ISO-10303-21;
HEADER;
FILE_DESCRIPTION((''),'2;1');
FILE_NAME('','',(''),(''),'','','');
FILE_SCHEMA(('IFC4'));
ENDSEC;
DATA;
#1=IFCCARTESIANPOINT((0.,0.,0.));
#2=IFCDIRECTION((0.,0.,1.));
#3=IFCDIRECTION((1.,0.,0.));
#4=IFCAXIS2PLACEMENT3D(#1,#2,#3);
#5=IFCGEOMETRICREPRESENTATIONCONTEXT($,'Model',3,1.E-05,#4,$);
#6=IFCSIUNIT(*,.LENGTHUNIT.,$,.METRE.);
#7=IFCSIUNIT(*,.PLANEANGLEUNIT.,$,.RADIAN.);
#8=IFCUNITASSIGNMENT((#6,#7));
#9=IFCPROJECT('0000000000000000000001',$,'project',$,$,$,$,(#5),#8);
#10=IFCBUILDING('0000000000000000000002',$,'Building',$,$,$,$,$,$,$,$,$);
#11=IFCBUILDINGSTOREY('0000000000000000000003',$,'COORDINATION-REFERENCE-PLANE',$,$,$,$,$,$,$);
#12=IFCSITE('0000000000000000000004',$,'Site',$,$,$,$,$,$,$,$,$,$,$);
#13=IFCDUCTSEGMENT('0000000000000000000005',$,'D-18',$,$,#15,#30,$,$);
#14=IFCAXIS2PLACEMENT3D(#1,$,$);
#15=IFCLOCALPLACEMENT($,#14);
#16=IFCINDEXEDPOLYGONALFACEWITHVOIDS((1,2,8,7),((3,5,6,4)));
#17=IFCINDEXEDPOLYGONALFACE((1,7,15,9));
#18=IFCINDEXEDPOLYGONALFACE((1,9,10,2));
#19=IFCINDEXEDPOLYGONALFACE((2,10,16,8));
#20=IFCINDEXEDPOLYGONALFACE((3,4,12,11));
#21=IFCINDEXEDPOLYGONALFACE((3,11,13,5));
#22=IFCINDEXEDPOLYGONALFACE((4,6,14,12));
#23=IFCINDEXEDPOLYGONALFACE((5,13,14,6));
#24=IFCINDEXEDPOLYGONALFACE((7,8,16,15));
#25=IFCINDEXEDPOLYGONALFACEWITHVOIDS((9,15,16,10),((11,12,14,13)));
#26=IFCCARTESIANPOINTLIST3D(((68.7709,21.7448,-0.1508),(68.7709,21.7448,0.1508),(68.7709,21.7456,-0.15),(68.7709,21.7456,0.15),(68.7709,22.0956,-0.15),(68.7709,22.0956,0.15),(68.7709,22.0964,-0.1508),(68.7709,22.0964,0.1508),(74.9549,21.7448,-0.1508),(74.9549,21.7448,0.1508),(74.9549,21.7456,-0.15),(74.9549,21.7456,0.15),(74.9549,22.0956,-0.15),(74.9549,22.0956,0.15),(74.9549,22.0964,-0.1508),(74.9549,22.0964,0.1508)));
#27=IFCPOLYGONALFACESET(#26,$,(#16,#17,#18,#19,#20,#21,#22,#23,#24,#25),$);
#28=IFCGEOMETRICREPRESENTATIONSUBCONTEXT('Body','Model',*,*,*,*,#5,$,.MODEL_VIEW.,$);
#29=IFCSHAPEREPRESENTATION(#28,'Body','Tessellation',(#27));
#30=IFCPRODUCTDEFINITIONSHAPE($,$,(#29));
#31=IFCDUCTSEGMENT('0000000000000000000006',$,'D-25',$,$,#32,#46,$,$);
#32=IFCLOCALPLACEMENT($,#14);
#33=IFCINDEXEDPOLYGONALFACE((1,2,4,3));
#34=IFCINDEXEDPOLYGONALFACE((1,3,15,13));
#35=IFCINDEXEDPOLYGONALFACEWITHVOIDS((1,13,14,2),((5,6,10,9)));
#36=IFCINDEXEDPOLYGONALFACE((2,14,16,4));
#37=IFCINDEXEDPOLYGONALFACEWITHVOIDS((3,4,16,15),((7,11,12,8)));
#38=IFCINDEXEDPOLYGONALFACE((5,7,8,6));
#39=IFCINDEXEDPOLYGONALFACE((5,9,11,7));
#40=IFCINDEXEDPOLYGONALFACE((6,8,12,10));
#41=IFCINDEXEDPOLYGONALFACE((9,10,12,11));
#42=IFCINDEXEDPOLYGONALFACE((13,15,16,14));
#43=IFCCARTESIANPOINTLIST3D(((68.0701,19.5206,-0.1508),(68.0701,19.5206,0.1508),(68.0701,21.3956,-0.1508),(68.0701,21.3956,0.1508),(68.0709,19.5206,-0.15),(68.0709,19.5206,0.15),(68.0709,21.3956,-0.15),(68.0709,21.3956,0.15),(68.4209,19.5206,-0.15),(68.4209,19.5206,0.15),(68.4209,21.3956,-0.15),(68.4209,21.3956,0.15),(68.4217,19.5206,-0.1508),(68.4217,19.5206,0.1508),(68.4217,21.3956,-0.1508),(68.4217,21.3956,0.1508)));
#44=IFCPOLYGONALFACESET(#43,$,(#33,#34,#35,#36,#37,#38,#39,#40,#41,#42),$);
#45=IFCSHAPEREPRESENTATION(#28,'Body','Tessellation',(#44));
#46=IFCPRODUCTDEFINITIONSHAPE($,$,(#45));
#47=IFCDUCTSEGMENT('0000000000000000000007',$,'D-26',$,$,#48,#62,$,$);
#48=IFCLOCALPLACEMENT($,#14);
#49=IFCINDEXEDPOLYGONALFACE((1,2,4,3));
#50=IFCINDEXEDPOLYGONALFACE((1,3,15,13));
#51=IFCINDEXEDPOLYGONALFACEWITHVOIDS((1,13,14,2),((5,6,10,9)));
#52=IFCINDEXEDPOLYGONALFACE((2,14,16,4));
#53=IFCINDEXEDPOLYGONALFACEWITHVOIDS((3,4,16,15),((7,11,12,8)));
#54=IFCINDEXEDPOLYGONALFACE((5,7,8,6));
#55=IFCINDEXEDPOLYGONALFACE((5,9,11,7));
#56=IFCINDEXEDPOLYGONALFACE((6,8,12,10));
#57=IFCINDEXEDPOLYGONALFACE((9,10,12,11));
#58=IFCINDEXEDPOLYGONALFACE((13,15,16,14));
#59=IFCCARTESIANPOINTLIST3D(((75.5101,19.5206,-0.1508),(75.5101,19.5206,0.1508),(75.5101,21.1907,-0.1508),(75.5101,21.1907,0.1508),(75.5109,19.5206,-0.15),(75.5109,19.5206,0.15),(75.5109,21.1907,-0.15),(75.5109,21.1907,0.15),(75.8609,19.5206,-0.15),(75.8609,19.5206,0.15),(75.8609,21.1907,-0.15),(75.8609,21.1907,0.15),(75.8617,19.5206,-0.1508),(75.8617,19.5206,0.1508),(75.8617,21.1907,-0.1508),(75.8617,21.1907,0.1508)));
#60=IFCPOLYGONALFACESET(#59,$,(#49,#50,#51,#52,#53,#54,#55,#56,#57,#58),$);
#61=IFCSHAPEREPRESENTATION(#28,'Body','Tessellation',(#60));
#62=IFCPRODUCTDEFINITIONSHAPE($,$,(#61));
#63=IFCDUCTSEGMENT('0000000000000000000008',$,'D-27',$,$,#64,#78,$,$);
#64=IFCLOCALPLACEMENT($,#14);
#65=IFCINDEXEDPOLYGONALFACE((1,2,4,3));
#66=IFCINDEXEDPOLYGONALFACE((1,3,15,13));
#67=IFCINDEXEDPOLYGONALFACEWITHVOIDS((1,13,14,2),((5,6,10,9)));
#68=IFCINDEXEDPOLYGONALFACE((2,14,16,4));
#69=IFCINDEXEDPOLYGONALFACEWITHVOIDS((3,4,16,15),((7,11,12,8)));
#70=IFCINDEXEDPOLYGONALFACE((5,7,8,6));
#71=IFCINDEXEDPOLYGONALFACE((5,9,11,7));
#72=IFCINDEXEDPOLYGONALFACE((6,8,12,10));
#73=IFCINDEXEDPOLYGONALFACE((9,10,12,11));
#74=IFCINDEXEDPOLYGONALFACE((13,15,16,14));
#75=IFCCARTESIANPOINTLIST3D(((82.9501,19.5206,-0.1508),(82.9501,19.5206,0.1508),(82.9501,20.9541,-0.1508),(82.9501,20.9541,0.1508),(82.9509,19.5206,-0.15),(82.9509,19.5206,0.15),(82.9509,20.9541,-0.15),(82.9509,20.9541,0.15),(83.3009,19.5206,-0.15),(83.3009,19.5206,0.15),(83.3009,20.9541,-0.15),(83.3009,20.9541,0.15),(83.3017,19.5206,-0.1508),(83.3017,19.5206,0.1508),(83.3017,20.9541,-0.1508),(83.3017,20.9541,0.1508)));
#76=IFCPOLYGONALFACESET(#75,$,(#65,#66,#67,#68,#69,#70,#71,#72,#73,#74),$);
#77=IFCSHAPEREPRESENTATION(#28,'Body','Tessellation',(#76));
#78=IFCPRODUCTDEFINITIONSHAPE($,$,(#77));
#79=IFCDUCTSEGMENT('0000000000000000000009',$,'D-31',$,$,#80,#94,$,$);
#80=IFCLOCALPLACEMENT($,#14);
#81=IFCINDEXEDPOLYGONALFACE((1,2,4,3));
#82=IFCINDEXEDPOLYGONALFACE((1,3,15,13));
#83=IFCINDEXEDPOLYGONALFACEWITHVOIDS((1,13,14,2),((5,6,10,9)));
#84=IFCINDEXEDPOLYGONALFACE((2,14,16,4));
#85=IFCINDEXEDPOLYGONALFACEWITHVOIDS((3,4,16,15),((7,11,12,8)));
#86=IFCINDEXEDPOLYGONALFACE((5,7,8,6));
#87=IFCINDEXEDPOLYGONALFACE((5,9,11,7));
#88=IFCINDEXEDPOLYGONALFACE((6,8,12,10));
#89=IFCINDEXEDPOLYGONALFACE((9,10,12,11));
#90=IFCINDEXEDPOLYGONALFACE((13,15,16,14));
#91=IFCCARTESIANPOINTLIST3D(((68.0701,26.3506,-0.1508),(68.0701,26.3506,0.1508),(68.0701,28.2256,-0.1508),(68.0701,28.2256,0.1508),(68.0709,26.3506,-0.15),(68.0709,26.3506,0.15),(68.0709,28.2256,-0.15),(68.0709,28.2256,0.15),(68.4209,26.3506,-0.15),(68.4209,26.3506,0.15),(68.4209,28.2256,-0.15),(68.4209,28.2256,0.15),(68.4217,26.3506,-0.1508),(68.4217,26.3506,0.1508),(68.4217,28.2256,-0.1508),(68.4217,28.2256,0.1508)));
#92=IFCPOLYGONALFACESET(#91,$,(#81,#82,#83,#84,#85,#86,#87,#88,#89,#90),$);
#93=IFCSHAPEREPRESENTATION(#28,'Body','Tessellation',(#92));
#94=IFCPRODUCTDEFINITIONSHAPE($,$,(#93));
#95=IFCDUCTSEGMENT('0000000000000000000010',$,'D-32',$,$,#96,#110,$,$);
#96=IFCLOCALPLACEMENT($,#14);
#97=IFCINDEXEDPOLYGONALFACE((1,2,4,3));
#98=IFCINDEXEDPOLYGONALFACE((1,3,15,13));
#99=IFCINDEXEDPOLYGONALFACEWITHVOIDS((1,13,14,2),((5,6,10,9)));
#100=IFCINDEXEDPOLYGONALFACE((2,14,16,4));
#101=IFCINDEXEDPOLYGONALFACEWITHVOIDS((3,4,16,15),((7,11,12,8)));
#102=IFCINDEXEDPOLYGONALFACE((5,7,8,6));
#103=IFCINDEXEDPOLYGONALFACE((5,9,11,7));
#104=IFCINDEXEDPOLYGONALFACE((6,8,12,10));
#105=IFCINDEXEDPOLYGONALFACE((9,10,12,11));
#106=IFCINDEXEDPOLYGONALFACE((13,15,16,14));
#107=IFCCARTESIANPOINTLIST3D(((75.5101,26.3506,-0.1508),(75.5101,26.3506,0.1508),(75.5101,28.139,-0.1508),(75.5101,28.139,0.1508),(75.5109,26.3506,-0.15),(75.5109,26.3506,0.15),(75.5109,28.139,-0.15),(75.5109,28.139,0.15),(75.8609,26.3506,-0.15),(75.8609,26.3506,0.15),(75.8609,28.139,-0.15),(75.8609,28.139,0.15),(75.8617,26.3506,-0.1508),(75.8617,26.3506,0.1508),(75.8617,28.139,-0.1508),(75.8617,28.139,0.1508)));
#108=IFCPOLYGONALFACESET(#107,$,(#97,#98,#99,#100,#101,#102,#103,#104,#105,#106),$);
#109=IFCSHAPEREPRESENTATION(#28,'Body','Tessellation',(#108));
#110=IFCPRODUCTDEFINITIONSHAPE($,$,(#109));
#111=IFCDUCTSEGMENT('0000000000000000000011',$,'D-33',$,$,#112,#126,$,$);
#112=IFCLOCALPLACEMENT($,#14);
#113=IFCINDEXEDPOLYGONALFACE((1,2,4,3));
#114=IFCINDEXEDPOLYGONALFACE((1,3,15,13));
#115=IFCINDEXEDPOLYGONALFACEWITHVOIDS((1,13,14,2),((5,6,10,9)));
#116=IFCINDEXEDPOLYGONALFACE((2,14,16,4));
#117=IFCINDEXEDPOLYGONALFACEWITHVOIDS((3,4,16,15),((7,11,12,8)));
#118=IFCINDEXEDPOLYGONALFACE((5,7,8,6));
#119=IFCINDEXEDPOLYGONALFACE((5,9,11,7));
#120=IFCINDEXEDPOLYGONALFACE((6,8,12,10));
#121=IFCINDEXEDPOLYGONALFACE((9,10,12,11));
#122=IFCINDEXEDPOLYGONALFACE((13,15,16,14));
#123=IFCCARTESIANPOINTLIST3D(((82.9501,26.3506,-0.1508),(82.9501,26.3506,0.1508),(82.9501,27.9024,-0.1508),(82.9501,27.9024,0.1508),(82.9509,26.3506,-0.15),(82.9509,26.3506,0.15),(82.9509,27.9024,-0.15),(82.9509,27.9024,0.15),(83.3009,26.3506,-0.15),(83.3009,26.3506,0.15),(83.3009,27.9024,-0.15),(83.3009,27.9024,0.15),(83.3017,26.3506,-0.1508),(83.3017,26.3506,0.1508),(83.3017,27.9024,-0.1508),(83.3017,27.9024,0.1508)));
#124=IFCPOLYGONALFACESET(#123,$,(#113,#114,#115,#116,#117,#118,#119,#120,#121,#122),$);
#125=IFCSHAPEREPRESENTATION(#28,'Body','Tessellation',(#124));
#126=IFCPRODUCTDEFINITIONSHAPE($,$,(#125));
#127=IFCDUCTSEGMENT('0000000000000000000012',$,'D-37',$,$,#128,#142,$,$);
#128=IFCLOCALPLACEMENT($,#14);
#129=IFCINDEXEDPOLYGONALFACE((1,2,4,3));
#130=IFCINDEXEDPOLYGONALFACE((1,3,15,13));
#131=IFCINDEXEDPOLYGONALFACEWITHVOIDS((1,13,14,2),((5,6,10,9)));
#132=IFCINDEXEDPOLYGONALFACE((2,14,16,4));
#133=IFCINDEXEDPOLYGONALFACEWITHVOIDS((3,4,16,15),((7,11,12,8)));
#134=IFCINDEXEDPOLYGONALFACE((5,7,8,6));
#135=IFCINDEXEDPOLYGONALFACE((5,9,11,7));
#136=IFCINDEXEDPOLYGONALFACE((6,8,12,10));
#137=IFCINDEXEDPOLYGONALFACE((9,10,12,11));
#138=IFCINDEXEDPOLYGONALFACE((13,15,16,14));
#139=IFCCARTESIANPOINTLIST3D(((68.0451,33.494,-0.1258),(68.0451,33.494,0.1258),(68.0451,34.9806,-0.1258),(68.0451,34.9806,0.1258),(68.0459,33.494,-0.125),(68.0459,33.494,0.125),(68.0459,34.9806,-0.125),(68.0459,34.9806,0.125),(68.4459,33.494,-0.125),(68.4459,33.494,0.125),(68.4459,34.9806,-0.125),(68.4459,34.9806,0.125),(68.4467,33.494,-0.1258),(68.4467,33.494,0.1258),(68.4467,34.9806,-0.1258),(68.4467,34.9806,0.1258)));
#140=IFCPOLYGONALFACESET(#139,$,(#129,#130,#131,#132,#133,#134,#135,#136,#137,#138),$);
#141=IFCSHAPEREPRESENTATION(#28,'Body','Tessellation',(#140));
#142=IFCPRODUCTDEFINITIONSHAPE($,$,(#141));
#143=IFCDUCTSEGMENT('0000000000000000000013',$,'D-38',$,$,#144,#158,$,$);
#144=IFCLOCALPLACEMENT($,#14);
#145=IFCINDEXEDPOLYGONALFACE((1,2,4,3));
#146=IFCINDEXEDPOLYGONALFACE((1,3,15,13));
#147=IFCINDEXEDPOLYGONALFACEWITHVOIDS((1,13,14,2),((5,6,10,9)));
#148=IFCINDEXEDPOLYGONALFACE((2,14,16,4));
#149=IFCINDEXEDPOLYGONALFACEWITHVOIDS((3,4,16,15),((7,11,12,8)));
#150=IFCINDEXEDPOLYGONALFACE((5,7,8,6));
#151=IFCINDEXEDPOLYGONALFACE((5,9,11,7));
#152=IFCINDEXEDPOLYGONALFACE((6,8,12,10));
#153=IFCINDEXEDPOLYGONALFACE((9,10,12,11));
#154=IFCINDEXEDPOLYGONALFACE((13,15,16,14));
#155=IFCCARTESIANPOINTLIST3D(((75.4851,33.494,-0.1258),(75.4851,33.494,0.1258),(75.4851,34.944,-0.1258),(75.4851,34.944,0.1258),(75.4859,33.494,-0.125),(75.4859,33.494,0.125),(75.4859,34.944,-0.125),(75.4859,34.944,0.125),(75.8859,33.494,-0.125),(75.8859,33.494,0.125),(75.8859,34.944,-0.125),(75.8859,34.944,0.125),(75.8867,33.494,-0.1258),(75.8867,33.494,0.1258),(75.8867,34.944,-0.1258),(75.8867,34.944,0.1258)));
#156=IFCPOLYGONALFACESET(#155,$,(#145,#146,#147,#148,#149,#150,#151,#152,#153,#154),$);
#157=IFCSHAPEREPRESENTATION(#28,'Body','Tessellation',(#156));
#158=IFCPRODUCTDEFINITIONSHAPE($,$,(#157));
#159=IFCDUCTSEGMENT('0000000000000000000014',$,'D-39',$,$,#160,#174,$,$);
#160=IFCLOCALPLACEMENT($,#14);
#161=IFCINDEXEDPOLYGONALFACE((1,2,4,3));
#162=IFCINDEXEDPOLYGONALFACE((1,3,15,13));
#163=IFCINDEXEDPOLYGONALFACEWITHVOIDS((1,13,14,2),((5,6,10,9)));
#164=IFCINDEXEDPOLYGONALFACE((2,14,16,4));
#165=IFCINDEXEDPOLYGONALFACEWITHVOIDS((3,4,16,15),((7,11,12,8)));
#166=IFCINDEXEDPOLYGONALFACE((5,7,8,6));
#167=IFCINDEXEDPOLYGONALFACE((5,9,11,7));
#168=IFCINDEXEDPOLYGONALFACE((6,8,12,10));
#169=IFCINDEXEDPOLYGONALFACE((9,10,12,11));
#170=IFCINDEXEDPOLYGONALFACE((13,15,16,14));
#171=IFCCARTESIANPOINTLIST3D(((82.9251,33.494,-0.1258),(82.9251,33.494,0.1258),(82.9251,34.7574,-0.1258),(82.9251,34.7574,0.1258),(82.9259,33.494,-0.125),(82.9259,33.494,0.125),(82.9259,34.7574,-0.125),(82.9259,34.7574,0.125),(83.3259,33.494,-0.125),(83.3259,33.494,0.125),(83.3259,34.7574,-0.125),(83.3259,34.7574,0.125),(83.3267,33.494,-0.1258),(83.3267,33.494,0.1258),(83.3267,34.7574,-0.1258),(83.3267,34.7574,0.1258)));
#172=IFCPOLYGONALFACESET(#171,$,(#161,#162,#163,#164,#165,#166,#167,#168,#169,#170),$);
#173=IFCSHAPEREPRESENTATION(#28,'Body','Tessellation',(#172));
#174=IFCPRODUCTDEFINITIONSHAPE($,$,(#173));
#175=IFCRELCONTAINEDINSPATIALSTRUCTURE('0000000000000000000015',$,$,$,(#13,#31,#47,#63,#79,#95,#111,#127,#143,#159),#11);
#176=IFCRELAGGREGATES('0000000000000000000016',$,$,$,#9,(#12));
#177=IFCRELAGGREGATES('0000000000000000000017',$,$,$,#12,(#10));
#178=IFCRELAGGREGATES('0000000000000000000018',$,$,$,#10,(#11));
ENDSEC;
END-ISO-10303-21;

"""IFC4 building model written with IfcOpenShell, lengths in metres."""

from ifc_helpers import new_model, si_unit, frame, origin, origin_with_axes, place, context, subcontext, project, spatial, hollow_rectangle, extrude, element, save


model = new_model("IFC4")

# Units and contexts
model_context = context("Model", 3, precision=1e-05, world=origin_with_axes())
body_context = subcontext(model_context, "Body", "Model", "MODEL_VIEW")
ifc_project = project(units=[si_unit("LENGTHUNIT", "METRE"), si_unit("PLANEANGLEUNIT", "RADIAN")], contexts=[model_context])

# Site, building, storey
site = spatial("IfcSite", under=ifc_project, Name="Site")
building = spatial("IfcBuilding", under=site, Name="Building")
storey = spatial("IfcBuildingStorey", under=building, Name="COORDINATION-REFERENCE-PLANE")

# Duct segments
duct_segment_1_placement = place(None, frame((68.7709, 21.9206, 0.0), z_axis=(1.0, 0.0, 0.0), x_axis=(0.0, 1.0, 0.0)))
element("IfcDuctSegment", 1, at=duct_segment_1_placement, inside=storey, Name="D-18", context=body_context, shape_type="SweptSolid", body=[
    extrude(hollow_rectangle(XDim=0.3516, YDim=0.3016, WallThickness=0.0008), origin(), (0.0, 0.0, 1.0), 6.1839),
])
duct_segment_2_placement = place(None, frame((68.2459, 19.5206, 0.0), z_axis=(0.0, 1.0, 0.0), x_axis=(1.0, 0.0, 0.0)))
element("IfcDuctSegment", 2, at=duct_segment_2_placement, inside=storey, Name="D-25", context=body_context, shape_type="SweptSolid", body=[
    extrude(hollow_rectangle(XDim=0.3516, YDim=0.3016, WallThickness=0.0008), origin(), (0.0, 0.0, 1.0), 1.875),
])
duct_segment_3_placement = place(None, frame((75.6859, 19.5206, 0.0), z_axis=(0.0, 1.0, 0.0), x_axis=(1.0, 0.0, 0.0)))
element("IfcDuctSegment", 3, at=duct_segment_3_placement, inside=storey, Name="D-26", context=body_context, shape_type="SweptSolid", body=[
    extrude(hollow_rectangle(XDim=0.3516, YDim=0.3016, WallThickness=0.0008), origin(), (0.0, 0.0, 1.0), 1.6701),
])
duct_segment_4_placement = place(None, frame((83.1259, 19.5206, 0.0), z_axis=(0.0, 1.0, 0.0), x_axis=(1.0, 0.0, 0.0)))
element("IfcDuctSegment", 4, at=duct_segment_4_placement, inside=storey, Name="D-27", context=body_context, shape_type="SweptSolid", body=[
    extrude(hollow_rectangle(XDim=0.3516, YDim=0.3016, WallThickness=0.0008), origin(), (0.0, 0.0, 1.0), 1.4335),
])
duct_segment_5_placement = place(None, frame((68.2459, 26.3506, 0.0), z_axis=(0.0, 1.0, 0.0), x_axis=(1.0, 0.0, 0.0)))
element("IfcDuctSegment", 5, at=duct_segment_5_placement, inside=storey, Name="D-31", context=body_context, shape_type="SweptSolid", body=[
    extrude(hollow_rectangle(XDim=0.3516, YDim=0.3016, WallThickness=0.0008), origin(), (0.0, 0.0, 1.0), 1.875),
])
duct_segment_6_placement = place(None, frame((75.6859, 26.3506, 0.0), z_axis=(0.0, 1.0, 0.0), x_axis=(1.0, 0.0, 0.0)))
element("IfcDuctSegment", 6, at=duct_segment_6_placement, inside=storey, Name="D-32", context=body_context, shape_type="SweptSolid", body=[
    extrude(hollow_rectangle(XDim=0.3516, YDim=0.3016, WallThickness=0.0008), origin(), (0.0, 0.0, 1.0), 1.7884),
])
duct_segment_7_placement = place(None, frame((83.1259, 26.3506, 0.0), z_axis=(0.0, 1.0, 0.0), x_axis=(1.0, 0.0, 0.0)))
element("IfcDuctSegment", 7, at=duct_segment_7_placement, inside=storey, Name="D-33", context=body_context, shape_type="SweptSolid", body=[
    extrude(hollow_rectangle(XDim=0.3516, YDim=0.3016, WallThickness=0.0008), origin(), (0.0, 0.0, 1.0), 1.5518),
])
duct_segment_8_placement = place(None, frame((68.2459, 33.494, 0.0), z_axis=(0.0, 1.0, 0.0), x_axis=(1.0, 0.0, 0.0)))
element("IfcDuctSegment", 8, at=duct_segment_8_placement, inside=storey, Name="D-37", context=body_context, shape_type="SweptSolid", body=[
    extrude(hollow_rectangle(XDim=0.4016, YDim=0.2516, WallThickness=0.0008), origin(), (0.0, 0.0, 1.0), 1.4865),
])
duct_segment_9_placement = place(None, frame((75.6859, 33.494, 0.0), z_axis=(0.0, 1.0, 0.0), x_axis=(1.0, 0.0, 0.0)))
element("IfcDuctSegment", 9, at=duct_segment_9_placement, inside=storey, Name="D-38", context=body_context, shape_type="SweptSolid", body=[
    extrude(hollow_rectangle(XDim=0.4016, YDim=0.2516, WallThickness=0.0008), origin(), (0.0, 0.0, 1.0), 1.4499),
])
duct_segment_10_placement = place(None, frame((83.1259, 33.494, 0.0), z_axis=(0.0, 1.0, 0.0), x_axis=(1.0, 0.0, 0.0)))
element("IfcDuctSegment", 10, at=duct_segment_10_placement, inside=storey, Name="D-39", context=body_context, shape_type="SweptSolid", body=[
    extrude(hollow_rectangle(XDim=0.4016, YDim=0.2516, WallThickness=0.0008), origin(), (0.0, 0.0, 1.0), 1.2633),
])

save(model, "model.ifc")
